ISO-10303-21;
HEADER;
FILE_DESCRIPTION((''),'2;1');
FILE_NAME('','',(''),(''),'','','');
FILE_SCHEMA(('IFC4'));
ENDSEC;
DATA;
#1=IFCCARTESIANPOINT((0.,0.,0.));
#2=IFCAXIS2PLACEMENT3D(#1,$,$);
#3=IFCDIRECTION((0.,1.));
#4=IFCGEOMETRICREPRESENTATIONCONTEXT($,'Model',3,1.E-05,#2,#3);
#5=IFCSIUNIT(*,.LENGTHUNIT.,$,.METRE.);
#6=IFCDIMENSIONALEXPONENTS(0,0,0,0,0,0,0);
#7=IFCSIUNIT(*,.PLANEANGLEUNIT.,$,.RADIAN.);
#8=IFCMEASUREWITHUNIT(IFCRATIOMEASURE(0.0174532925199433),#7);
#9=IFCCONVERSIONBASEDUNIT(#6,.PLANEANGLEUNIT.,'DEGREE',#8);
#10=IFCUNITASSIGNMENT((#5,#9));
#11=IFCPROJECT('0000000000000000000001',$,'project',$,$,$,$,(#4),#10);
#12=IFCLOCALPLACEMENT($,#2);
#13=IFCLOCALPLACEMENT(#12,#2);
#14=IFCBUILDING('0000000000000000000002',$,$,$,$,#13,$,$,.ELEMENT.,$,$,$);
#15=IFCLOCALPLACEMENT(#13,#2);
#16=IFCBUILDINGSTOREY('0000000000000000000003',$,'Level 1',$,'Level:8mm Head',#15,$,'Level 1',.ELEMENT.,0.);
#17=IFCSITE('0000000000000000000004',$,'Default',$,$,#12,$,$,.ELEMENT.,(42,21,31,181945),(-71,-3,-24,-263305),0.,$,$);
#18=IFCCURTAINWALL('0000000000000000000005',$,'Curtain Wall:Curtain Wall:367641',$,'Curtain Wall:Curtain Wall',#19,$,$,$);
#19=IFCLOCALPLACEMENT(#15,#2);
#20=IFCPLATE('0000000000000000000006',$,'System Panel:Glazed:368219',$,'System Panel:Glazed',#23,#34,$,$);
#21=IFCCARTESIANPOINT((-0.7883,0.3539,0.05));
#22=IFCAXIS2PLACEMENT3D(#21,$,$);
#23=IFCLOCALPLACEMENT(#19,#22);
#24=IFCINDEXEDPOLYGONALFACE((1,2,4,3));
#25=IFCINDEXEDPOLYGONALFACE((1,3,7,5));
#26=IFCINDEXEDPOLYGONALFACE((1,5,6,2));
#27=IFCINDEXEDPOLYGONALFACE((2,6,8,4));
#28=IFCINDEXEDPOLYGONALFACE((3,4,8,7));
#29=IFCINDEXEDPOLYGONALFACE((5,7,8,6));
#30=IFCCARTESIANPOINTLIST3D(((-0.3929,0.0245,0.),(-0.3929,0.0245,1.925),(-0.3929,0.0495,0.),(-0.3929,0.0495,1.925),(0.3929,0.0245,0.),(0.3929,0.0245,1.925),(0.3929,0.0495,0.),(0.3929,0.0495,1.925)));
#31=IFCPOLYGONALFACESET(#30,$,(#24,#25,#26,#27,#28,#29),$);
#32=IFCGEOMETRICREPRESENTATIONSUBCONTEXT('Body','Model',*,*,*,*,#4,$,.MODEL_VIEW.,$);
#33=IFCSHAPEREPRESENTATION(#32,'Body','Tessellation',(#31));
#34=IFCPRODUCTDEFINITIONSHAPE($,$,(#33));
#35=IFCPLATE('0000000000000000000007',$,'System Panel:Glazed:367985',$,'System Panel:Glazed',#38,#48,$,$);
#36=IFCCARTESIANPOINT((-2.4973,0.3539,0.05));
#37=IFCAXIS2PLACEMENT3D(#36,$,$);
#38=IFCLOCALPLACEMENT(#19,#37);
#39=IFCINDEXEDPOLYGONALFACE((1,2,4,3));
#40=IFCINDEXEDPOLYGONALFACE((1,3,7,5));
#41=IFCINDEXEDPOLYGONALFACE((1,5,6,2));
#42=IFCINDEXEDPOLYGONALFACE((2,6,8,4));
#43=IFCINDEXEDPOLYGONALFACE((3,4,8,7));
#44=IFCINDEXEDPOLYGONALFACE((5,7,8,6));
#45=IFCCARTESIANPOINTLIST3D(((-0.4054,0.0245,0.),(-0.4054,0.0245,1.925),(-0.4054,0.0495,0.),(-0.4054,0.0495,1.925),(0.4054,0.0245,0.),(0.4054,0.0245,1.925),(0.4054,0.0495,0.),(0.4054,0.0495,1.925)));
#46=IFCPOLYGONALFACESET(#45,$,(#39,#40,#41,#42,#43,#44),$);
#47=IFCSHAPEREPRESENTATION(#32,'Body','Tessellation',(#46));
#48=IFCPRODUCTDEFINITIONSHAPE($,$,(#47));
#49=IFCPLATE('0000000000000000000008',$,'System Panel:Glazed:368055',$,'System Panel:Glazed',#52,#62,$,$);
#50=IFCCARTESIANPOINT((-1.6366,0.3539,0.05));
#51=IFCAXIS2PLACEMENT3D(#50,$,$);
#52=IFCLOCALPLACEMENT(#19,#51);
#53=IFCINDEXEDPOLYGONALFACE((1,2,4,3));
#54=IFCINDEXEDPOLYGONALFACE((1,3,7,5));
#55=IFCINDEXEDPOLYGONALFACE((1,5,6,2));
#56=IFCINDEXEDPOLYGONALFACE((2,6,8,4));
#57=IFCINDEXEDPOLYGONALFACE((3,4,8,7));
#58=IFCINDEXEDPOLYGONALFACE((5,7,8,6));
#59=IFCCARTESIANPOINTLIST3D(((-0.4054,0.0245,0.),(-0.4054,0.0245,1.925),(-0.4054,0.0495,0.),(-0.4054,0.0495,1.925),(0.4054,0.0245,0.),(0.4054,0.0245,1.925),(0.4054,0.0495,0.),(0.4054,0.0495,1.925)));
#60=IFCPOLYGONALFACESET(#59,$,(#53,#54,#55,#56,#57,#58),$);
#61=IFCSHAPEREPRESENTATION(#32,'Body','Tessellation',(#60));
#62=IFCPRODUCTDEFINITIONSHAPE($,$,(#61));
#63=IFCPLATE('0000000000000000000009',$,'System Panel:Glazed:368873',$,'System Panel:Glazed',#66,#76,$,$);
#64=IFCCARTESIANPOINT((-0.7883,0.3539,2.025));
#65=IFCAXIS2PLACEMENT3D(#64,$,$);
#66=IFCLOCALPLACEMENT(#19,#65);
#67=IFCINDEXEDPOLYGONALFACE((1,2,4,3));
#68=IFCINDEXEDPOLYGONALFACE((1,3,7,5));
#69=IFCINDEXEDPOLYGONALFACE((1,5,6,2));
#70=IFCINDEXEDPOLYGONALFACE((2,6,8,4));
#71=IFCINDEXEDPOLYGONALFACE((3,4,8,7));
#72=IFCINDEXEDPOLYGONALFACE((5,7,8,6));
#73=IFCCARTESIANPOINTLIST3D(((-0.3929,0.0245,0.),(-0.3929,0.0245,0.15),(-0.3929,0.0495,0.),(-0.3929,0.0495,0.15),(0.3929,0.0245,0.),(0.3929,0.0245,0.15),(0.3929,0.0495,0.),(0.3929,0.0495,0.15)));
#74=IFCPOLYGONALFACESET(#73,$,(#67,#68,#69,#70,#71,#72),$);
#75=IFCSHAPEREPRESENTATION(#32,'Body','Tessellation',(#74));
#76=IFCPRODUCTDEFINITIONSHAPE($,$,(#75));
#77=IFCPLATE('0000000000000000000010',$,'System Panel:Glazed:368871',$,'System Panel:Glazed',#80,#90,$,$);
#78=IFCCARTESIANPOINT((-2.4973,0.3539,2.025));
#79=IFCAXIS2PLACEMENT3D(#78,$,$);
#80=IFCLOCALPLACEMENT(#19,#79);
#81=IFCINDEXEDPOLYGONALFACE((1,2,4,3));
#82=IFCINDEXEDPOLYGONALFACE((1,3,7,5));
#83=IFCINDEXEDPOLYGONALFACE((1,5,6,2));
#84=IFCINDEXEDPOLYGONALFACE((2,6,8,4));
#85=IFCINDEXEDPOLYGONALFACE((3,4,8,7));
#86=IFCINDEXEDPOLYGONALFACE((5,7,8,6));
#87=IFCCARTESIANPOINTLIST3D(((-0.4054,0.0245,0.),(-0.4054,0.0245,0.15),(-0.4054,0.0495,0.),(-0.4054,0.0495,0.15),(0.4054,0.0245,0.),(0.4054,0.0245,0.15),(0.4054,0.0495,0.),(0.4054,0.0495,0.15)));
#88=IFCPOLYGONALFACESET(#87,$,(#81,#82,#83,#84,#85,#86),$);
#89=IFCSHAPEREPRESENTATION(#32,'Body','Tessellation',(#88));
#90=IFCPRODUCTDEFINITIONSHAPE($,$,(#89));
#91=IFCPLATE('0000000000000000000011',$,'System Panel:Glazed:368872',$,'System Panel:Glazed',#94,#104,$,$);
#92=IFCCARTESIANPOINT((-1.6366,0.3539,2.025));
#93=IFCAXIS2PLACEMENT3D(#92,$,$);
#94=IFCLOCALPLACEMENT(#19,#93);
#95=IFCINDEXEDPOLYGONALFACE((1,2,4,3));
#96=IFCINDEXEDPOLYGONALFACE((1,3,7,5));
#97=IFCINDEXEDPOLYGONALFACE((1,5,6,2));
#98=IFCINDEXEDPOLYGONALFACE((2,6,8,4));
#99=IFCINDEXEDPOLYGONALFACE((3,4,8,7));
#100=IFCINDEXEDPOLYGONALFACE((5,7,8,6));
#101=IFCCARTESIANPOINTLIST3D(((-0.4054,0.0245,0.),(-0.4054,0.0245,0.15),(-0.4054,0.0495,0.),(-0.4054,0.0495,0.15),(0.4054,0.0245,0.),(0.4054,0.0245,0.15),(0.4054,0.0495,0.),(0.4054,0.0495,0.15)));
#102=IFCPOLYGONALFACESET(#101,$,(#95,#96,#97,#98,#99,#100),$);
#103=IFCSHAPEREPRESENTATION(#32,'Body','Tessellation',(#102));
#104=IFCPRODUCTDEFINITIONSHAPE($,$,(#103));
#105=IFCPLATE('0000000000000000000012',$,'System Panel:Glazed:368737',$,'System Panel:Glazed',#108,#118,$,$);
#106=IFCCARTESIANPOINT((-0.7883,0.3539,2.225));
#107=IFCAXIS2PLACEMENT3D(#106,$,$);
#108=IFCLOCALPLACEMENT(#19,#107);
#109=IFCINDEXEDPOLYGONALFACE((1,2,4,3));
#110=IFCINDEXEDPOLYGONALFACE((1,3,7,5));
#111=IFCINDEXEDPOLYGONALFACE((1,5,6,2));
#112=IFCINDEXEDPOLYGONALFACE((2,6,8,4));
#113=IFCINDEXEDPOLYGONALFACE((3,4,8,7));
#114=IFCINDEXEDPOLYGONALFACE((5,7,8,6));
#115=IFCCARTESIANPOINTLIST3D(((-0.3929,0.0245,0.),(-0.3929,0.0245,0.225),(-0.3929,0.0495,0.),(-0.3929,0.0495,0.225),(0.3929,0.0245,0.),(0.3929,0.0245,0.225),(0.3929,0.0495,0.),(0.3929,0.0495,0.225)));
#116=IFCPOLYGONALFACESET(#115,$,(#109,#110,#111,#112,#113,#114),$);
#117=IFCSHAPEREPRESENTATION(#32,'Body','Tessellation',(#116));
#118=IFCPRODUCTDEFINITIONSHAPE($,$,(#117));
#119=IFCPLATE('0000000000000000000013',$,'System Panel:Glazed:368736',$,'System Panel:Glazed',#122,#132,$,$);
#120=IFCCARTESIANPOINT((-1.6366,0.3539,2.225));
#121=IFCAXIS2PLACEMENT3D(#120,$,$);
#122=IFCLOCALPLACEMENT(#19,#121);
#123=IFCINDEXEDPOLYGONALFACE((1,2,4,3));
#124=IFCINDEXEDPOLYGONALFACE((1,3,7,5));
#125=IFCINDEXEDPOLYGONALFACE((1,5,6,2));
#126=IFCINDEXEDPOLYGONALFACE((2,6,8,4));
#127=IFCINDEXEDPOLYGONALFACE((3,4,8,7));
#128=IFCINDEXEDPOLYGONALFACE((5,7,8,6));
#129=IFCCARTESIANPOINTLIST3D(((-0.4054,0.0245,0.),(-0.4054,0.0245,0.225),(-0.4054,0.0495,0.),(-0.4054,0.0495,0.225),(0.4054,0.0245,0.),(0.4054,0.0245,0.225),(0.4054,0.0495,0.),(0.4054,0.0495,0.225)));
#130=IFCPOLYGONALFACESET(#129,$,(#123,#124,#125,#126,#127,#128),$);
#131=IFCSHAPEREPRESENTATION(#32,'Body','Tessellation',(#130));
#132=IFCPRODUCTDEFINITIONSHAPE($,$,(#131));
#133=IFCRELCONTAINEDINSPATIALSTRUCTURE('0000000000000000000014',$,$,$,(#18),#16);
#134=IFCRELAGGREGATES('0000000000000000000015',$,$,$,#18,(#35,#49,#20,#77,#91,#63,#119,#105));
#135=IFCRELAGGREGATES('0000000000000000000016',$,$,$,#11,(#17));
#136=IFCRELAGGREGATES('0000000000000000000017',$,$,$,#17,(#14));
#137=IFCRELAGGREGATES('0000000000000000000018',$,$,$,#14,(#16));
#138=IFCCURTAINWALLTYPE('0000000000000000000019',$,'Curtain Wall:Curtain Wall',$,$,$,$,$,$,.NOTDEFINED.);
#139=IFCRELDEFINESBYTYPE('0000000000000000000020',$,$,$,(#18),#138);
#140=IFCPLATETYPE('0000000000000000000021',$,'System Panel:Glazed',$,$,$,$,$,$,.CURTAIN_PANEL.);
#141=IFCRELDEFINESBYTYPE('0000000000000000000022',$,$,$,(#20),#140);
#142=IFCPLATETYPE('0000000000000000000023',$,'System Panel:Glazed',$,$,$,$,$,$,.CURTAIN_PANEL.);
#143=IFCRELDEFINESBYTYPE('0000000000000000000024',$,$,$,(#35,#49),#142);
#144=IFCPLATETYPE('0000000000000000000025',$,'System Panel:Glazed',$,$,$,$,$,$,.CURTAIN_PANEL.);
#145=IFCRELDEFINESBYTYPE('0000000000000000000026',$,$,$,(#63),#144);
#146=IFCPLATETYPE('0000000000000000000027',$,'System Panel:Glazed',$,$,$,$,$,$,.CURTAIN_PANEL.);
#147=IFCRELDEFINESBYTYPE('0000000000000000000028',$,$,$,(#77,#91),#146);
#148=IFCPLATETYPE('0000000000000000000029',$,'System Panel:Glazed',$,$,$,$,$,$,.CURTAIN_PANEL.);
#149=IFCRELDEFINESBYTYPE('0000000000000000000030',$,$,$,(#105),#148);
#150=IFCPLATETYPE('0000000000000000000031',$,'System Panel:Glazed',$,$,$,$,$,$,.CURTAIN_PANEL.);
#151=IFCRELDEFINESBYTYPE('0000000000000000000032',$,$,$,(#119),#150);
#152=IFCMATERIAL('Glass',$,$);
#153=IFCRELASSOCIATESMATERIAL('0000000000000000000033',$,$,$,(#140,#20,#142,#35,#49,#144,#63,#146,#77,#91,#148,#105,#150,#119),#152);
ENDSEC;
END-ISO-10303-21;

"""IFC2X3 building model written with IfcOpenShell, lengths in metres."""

from ifc_helpers import new_model, entity, si_unit, converted_unit, direction, frame, origin, origin_2d_with_axis, place, context, subcontext, project, spatial, rectangle, extrude, source, transform, mapped, material, type_object, type_shapes, element, aggregate, save


model = new_model("IFC2X3")

# Units and contexts
model_context = context("Model", 3, precision=1e-05, world=origin(), true_north=direction((0.0, 1.0)))
body_context = subcontext(model_context, "Body", "Model", "MODEL_VIEW")
ifc_project = project(units=[si_unit("LENGTHUNIT", "METRE"), converted_unit("PLANEANGLEUNIT", "DEGREE", entity("IfcRatioMeasure", 0.0174532925199433), si_unit("PLANEANGLEUNIT", "RADIAN"), dimensions=[0, 0, 0, 0, 0, 0, 0])], contexts=[model_context])

# Site, building, storey
site_placement = place(None, origin())
site = spatial("IfcSite", under=ifc_project, at=site_placement, Name="Default", CompositionType="ELEMENT", RefLatitude=(42, 21, 31, 181945), RefLongitude=(-71, -3, -24, -263305), RefElevation=0.0)
building_placement = place(site_placement, origin())
building = spatial("IfcBuilding", under=site, at=building_placement, CompositionType="ELEMENT")
storey_placement = place(building_placement, origin())
storey = spatial("IfcBuildingStorey", under=building, at=storey_placement, Name="Level 1", ObjectType="Level:8mm Head", LongName="Level 1", CompositionType="ELEMENT", Elevation=0.0)

# Curtain wall
curtain_wall_type = type_object("IfcCurtainWallType", Name="Curtain Wall:Curtain Wall", PredefinedType="NOTDEFINED")
curtain_wall_placement = place(storey_placement, origin())
curtain_wall = element("IfcCurtainWall", 1, at=curtain_wall_placement, inside=storey, type_object=curtain_wall_type, Name="Curtain Wall:Curtain Wall:367641", ObjectType="Curtain Wall:Curtain Wall")

# Plates
ifc_material_1 = material(Name="Glass")
plate_type_1 = type_object("IfcPlateType", Name="System Panel:Glazed", PredefinedType="CURTAIN_PANEL", material=ifc_material_1)
shared_shape_1 = source(origin(), body_context, "Body", "SweptSolid", [
    extrude(rectangle(XDim=0.025, YDim=0.7857, at=origin_2d_with_axis()), frame((0.0, 0.037, 0.0), z_axis=(0.0, 0.0, 1.0), x_axis=(0.0, 1.0, 0.0)), (0.0, 0.0, 1.0), 1.925),
])
type_shapes(plate_type_1, [shared_shape_1])
plate_1_placement = place(curtain_wall_placement, frame((-0.7883, 0.3539, 0.05)))
plate_1 = element("IfcPlate", 2, at=plate_1_placement, type_object=plate_type_1, material=ifc_material_1, Name="System Panel:Glazed:368219", ObjectType="System Panel:Glazed", context=body_context, shape_type="MappedRepresentation", body=[
    mapped(shared_shape_1, transform((0.0, 0.0, 0.0), scale=1.0)),
])
plate_type_2 = type_object("IfcPlateType", Name="System Panel:Glazed", PredefinedType="CURTAIN_PANEL", material=ifc_material_1)
shared_shape_2 = source(origin(), body_context, "Body", "SweptSolid", [
    extrude(rectangle(XDim=0.025, YDim=0.8107, at=origin_2d_with_axis()), frame((0.0, 0.037, 0.0), z_axis=(0.0, 0.0, 1.0), x_axis=(0.0, 1.0, 0.0)), (0.0, 0.0, 1.0), 1.925),
])
type_shapes(plate_type_2, [shared_shape_2])
plate_2_placement = place(curtain_wall_placement, frame((-2.4973, 0.3539, 0.05)))
plate_2 = element("IfcPlate", 3, at=plate_2_placement, type_object=plate_type_2, material=ifc_material_1, Name="System Panel:Glazed:367985", ObjectType="System Panel:Glazed", context=body_context, shape_type="MappedRepresentation", body=[
    mapped(shared_shape_2, transform((0.0, 0.0, 0.0), scale=1.0)),
])
plate_3_placement = place(curtain_wall_placement, frame((-1.6366, 0.3539, 0.05)))
plate_3 = element("IfcPlate", 4, at=plate_3_placement, type_object=plate_type_2, material=ifc_material_1, Name="System Panel:Glazed:368055", ObjectType="System Panel:Glazed", context=body_context, shape_type="MappedRepresentation", body=[
    mapped(shared_shape_2, transform((0.0, 0.0, 0.0), scale=1.0)),
])
plate_type_3 = type_object("IfcPlateType", Name="System Panel:Glazed", PredefinedType="CURTAIN_PANEL", material=ifc_material_1)
shared_shape_3 = source(origin(), body_context, "Body", "SweptSolid", [
    extrude(rectangle(XDim=0.025, YDim=0.7857, at=origin_2d_with_axis()), frame((0.0, 0.037, 0.0), z_axis=(0.0, 0.0, 1.0), x_axis=(0.0, 1.0, 0.0)), (0.0, 0.0, 1.0), 0.15),
])
type_shapes(plate_type_3, [shared_shape_3])
plate_4_placement = place(curtain_wall_placement, frame((-0.7883, 0.3539, 2.025)))
plate_4 = element("IfcPlate", 5, at=plate_4_placement, type_object=plate_type_3, material=ifc_material_1, Name="System Panel:Glazed:368873", ObjectType="System Panel:Glazed", context=body_context, shape_type="MappedRepresentation", body=[
    mapped(shared_shape_3, transform((0.0, 0.0, 0.0), scale=1.0)),
])
plate_type_4 = type_object("IfcPlateType", Name="System Panel:Glazed", PredefinedType="CURTAIN_PANEL", material=ifc_material_1)
shared_shape_4 = source(origin(), body_context, "Body", "SweptSolid", [
    extrude(rectangle(XDim=0.025, YDim=0.8107, at=origin_2d_with_axis()), frame((0.0, 0.037, 0.0), z_axis=(0.0, 0.0, 1.0), x_axis=(0.0, 1.0, 0.0)), (0.0, 0.0, 1.0), 0.15),
])
type_shapes(plate_type_4, [shared_shape_4])
plate_5_placement = place(curtain_wall_placement, frame((-2.4973, 0.3539, 2.025)))
plate_5 = element("IfcPlate", 6, at=plate_5_placement, type_object=plate_type_4, material=ifc_material_1, Name="System Panel:Glazed:368871", ObjectType="System Panel:Glazed", context=body_context, shape_type="MappedRepresentation", body=[
    mapped(shared_shape_4, transform((0.0, 0.0, 0.0), scale=1.0)),
])
plate_6_placement = place(curtain_wall_placement, frame((-1.6366, 0.3539, 2.025)))
plate_6 = element("IfcPlate", 7, at=plate_6_placement, type_object=plate_type_4, material=ifc_material_1, Name="System Panel:Glazed:368872", ObjectType="System Panel:Glazed", context=body_context, shape_type="MappedRepresentation", body=[
    mapped(shared_shape_4, transform((0.0, 0.0, 0.0), scale=1.0)),
])
plate_type_5 = type_object("IfcPlateType", Name="System Panel:Glazed", PredefinedType="CURTAIN_PANEL", material=ifc_material_1)
shared_shape_5 = source(origin(), body_context, "Body", "SweptSolid", [
    extrude(rectangle(XDim=0.025, YDim=0.7857, at=origin_2d_with_axis()), frame((0.0, 0.037, 0.0), z_axis=(0.0, 0.0, 1.0), x_axis=(0.0, 1.0, 0.0)), (0.0, 0.0, 1.0), 0.225),
])
type_shapes(plate_type_5, [shared_shape_5])
plate_7_placement = place(curtain_wall_placement, frame((-0.7883, 0.3539, 2.225)))
plate_7 = element("IfcPlate", 8, at=plate_7_placement, type_object=plate_type_5, material=ifc_material_1, Name="System Panel:Glazed:368737", ObjectType="System Panel:Glazed", context=body_context, shape_type="MappedRepresentation", body=[
    mapped(shared_shape_5, transform((0.0, 0.0, 0.0), scale=1.0)),
])
plate_type_6 = type_object("IfcPlateType", Name="System Panel:Glazed", PredefinedType="CURTAIN_PANEL", material=ifc_material_1)
shared_shape_6 = source(origin(), body_context, "Body", "SweptSolid", [
    extrude(rectangle(XDim=0.025, YDim=0.8107, at=origin_2d_with_axis()), frame((0.0, 0.037, 0.0), z_axis=(0.0, 0.0, 1.0), x_axis=(0.0, 1.0, 0.0)), (0.0, 0.0, 1.0), 0.225),
])
type_shapes(plate_type_6, [shared_shape_6])
plate_8_placement = place(curtain_wall_placement, frame((-1.6366, 0.3539, 2.225)))
plate_8 = element("IfcPlate", 9, at=plate_8_placement, type_object=plate_type_6, material=ifc_material_1, Name="System Panel:Glazed:368736", ObjectType="System Panel:Glazed", context=body_context, shape_type="MappedRepresentation", body=[
    mapped(shared_shape_6, transform((0.0, 0.0, 0.0), scale=1.0)),
])
aggregate(curtain_wall, [plate_2, plate_3, plate_1, plate_5, plate_6, plate_4, plate_8, plate_7])

save(model, "model.ifc")
